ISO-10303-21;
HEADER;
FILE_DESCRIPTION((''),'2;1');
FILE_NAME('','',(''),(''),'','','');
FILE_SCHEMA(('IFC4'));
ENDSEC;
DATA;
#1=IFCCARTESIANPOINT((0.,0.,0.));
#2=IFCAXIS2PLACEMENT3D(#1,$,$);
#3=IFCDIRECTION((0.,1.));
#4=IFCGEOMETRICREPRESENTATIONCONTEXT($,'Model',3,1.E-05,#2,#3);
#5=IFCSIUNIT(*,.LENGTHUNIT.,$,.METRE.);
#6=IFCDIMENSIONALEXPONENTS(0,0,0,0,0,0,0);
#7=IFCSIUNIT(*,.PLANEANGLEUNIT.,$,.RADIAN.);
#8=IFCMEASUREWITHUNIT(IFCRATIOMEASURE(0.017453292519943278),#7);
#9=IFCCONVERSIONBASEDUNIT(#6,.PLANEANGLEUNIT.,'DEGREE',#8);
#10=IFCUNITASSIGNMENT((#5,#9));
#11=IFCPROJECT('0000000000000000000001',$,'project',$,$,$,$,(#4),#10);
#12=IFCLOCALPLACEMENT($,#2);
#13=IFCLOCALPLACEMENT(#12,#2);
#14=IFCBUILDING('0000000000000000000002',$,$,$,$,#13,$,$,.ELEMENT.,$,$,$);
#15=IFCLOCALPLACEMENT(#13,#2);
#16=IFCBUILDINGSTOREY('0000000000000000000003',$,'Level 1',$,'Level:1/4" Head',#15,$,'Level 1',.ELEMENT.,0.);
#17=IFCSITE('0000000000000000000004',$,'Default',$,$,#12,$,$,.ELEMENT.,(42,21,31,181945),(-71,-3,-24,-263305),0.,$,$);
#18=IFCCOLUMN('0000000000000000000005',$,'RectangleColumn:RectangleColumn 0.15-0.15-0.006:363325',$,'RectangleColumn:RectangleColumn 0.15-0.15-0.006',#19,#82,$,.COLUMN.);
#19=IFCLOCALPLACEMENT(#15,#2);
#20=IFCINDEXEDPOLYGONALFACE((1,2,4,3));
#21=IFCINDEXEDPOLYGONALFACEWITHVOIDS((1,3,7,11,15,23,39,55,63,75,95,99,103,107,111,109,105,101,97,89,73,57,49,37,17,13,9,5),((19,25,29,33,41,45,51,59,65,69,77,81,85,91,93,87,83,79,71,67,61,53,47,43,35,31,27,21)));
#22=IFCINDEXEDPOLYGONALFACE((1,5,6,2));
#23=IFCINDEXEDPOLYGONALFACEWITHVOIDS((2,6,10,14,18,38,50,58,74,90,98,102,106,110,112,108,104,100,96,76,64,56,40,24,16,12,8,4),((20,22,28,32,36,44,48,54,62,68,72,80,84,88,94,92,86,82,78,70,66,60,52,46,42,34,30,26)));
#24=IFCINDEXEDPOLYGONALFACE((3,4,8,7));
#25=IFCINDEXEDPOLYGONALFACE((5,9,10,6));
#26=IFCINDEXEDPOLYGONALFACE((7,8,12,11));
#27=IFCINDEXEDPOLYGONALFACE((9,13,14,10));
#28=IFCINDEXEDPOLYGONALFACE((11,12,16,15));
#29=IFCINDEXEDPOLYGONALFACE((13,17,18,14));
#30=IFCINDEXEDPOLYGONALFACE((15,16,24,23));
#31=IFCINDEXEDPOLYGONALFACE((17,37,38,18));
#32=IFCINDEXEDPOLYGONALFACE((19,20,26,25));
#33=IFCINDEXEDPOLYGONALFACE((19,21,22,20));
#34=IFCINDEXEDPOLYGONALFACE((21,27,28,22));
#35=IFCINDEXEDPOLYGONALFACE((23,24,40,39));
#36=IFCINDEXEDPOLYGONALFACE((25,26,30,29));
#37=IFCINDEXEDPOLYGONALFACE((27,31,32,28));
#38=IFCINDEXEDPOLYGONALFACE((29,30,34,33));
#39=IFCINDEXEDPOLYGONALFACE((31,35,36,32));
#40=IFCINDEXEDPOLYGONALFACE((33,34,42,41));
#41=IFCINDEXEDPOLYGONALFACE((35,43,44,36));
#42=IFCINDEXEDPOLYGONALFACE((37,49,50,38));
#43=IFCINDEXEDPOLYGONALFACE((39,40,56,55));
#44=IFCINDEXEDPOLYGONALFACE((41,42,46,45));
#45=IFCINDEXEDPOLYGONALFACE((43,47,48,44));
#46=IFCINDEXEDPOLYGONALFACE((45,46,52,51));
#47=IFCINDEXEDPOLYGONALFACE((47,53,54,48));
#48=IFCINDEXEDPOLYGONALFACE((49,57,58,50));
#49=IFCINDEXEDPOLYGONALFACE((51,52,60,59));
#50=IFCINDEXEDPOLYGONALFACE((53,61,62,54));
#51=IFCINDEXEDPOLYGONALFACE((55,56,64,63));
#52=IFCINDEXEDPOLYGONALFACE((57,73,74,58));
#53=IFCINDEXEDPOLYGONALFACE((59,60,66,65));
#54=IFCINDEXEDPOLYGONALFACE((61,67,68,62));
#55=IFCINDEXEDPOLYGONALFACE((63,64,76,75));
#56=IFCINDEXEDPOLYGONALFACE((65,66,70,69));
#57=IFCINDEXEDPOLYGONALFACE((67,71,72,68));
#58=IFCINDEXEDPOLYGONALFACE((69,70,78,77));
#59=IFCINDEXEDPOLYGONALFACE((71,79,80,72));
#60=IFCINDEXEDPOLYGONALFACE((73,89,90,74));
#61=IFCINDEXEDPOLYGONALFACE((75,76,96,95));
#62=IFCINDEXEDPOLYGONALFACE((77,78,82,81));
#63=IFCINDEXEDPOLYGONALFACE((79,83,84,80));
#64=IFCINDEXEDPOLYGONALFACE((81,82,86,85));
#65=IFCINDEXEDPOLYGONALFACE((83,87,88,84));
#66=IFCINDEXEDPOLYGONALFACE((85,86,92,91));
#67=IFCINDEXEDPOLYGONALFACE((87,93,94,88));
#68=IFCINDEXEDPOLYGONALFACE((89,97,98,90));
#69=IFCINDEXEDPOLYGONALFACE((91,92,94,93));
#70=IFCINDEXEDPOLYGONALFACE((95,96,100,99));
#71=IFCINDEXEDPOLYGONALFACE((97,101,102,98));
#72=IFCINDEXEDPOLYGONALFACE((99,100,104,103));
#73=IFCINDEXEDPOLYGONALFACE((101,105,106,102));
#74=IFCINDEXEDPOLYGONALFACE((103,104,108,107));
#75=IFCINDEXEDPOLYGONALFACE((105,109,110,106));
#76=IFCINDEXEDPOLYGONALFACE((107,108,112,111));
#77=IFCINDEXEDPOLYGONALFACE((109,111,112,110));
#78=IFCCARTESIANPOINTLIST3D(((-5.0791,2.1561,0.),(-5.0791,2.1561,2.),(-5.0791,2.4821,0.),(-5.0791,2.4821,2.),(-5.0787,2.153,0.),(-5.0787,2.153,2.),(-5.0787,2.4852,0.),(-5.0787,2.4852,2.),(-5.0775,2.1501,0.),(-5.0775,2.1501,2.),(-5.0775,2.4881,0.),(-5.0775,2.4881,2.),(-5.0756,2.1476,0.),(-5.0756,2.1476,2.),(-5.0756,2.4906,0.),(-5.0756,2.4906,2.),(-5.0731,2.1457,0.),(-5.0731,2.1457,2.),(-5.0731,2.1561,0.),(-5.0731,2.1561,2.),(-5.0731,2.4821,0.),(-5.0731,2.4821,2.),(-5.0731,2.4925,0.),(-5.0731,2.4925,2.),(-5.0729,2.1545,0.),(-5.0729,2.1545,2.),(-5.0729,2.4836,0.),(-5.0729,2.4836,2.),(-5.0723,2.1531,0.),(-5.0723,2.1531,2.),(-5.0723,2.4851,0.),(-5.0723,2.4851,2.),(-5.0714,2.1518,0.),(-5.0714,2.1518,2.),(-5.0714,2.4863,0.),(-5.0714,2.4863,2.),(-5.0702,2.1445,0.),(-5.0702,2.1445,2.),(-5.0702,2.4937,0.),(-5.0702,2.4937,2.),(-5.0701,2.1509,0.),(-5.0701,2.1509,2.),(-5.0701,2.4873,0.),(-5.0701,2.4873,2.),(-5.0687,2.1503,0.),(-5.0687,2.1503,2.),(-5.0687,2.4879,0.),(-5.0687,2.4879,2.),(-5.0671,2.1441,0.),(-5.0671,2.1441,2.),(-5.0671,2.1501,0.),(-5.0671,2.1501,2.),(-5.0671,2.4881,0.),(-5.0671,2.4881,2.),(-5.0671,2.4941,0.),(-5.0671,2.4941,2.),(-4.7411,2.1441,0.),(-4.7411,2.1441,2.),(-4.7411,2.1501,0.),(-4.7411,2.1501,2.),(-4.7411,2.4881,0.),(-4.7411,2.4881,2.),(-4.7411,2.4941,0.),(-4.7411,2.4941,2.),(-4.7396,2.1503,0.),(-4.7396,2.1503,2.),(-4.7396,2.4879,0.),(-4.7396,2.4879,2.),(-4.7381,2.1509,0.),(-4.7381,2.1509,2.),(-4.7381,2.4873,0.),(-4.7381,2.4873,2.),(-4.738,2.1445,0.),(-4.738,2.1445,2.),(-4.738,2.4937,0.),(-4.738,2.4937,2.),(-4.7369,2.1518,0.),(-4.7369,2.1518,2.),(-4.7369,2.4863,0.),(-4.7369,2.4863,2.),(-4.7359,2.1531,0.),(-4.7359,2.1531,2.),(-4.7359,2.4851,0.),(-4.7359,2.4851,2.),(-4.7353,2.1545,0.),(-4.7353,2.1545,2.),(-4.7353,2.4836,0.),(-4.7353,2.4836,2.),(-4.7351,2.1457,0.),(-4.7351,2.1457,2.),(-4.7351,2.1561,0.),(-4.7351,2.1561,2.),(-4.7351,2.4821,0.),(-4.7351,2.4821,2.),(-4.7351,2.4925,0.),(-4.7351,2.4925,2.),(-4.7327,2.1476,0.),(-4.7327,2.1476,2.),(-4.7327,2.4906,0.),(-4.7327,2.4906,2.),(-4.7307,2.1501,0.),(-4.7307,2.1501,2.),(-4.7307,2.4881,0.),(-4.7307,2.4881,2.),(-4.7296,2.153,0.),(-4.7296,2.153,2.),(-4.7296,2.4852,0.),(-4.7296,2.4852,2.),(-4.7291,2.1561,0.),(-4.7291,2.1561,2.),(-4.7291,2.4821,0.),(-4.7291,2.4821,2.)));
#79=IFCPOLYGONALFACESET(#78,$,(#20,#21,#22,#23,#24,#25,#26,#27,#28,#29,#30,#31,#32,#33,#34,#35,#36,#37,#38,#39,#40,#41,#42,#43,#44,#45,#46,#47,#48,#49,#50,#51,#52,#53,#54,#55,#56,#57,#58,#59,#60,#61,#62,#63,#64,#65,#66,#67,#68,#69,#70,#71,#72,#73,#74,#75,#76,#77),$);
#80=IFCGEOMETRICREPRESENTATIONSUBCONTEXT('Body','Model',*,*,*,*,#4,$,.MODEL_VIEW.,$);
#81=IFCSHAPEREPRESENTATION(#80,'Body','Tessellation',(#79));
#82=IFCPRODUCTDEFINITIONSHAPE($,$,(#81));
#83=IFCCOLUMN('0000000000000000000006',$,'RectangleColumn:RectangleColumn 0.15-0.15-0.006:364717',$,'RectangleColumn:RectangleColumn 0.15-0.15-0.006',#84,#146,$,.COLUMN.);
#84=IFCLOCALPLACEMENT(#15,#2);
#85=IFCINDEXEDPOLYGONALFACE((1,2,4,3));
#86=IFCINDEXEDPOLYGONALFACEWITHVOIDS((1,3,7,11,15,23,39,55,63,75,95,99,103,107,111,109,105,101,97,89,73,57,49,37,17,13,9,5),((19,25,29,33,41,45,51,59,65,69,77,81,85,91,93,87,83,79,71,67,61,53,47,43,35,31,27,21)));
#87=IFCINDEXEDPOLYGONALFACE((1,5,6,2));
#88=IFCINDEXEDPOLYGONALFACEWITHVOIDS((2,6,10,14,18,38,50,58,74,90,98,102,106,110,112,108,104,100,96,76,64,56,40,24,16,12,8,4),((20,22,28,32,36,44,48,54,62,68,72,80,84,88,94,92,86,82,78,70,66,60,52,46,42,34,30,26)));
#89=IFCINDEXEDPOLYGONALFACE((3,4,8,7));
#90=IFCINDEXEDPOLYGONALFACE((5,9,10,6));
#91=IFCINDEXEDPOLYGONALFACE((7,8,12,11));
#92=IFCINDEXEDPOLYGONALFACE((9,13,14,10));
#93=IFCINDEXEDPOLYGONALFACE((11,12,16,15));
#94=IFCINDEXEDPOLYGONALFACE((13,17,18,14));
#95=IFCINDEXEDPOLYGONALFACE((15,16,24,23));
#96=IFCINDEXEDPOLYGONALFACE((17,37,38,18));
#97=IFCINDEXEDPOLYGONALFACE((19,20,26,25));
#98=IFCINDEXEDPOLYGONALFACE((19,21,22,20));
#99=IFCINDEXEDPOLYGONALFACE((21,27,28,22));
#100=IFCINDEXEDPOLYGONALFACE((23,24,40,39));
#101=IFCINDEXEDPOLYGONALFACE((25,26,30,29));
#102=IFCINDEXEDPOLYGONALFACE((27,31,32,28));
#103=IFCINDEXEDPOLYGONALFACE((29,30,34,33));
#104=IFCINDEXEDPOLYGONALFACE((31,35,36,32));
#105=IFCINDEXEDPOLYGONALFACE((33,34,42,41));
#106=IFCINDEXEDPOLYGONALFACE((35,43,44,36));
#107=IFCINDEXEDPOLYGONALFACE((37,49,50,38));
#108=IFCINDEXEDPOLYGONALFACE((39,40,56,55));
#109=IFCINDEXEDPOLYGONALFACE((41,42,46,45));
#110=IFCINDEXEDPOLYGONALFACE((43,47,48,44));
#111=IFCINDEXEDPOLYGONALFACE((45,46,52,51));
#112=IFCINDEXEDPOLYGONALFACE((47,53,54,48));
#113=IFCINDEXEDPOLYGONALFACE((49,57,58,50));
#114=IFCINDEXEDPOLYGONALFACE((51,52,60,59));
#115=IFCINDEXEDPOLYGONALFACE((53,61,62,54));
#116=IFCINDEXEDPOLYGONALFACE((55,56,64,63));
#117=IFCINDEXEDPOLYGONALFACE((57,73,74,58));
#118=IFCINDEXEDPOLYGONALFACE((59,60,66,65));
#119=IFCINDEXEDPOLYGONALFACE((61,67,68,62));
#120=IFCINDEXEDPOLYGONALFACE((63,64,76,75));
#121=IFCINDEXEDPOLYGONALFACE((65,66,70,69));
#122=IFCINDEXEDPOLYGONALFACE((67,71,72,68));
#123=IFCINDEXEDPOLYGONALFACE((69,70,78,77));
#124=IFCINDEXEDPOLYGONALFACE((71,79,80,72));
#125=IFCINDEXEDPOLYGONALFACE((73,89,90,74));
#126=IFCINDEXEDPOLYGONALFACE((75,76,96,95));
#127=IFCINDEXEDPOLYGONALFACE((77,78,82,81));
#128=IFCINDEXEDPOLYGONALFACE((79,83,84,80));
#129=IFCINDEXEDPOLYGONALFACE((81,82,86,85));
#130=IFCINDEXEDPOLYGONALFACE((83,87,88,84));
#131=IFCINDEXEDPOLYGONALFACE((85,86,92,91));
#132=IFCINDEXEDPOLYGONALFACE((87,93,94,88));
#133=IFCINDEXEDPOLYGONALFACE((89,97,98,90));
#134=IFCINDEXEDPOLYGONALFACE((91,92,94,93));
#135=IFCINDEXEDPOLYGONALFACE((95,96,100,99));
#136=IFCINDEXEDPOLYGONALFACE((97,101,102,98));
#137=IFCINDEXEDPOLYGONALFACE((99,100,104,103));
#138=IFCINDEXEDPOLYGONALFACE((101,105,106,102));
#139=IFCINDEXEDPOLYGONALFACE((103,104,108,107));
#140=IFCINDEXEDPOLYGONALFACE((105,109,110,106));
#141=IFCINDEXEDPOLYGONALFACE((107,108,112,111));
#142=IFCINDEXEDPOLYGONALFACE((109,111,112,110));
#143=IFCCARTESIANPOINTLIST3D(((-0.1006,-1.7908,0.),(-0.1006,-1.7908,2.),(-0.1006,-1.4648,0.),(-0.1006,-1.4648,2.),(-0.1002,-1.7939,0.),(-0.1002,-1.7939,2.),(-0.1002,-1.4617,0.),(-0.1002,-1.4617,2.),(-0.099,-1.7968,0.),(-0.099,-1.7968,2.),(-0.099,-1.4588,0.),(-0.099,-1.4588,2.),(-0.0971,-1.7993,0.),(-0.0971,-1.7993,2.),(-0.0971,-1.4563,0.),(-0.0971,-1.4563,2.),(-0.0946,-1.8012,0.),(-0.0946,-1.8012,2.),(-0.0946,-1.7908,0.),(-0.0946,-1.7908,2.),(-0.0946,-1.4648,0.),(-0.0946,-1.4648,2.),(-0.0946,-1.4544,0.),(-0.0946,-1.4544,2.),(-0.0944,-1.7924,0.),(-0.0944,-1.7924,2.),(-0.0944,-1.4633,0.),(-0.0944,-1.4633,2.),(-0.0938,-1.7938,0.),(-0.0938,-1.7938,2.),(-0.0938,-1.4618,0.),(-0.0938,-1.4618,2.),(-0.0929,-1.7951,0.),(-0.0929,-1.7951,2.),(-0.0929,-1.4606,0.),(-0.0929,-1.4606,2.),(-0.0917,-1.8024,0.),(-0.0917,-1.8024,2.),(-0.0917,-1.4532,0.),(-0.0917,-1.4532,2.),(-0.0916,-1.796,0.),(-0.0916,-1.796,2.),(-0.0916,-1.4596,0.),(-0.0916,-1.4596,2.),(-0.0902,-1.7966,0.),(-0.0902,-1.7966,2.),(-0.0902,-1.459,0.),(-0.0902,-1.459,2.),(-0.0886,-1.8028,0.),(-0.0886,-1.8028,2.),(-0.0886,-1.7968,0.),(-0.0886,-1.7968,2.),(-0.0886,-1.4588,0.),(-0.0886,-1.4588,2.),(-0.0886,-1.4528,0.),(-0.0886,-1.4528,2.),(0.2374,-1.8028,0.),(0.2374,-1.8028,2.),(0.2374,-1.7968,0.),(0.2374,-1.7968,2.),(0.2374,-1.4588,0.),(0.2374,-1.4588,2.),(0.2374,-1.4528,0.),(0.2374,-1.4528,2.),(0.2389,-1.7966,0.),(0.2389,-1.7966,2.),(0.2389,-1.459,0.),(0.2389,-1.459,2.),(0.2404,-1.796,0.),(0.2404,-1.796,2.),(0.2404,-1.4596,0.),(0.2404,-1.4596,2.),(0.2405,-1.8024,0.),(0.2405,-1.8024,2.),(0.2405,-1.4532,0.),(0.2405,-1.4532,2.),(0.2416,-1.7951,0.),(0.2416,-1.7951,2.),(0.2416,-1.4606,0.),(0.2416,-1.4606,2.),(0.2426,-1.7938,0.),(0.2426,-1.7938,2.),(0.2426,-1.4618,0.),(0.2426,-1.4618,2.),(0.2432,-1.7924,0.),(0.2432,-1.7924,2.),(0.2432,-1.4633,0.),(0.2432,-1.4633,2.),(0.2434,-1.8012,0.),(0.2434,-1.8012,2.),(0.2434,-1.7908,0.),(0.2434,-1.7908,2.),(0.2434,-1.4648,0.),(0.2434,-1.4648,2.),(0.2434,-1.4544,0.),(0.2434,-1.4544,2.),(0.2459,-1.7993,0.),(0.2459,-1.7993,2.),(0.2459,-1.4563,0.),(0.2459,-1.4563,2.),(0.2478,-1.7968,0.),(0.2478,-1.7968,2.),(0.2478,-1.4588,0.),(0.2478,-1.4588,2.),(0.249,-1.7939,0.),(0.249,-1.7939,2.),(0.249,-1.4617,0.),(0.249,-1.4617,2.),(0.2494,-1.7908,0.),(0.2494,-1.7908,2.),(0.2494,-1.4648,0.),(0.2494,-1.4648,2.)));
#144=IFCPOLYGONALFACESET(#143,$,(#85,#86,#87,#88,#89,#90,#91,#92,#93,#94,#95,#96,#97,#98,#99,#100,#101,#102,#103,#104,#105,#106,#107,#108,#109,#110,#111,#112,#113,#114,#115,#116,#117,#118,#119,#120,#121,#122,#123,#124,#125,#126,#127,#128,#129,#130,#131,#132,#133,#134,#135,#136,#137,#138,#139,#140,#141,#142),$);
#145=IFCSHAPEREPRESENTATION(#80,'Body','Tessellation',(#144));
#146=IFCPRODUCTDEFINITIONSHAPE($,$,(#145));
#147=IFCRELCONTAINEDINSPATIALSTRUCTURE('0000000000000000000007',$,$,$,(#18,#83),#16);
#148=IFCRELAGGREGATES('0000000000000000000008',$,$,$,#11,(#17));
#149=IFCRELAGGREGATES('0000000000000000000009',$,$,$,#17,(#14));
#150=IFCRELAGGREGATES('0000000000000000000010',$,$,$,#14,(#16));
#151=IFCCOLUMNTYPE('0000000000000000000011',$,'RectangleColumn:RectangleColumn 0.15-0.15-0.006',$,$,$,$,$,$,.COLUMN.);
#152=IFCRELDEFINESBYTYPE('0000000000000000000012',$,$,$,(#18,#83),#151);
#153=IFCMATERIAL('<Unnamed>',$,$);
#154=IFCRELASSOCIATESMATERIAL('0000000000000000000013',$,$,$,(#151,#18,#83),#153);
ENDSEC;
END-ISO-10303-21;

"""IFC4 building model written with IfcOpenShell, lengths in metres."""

from ifc_helpers import new_model, entity, si_unit, converted_unit, direction, frame, origin, place, context, subcontext, project, spatial, line, arc, indexed_curve, outline, extrude, source, transform, mapped, material, type_object, type_shapes, element, save


model = new_model("IFC4")

# Units and contexts
model_context = context("Model", 3, precision=1e-05, world=origin(), true_north=direction((0.0, 1.0)))
body_context = subcontext(model_context, "Body", "Model", "MODEL_VIEW")
ifc_project = project(units=[si_unit("LENGTHUNIT", "METRE"), converted_unit("PLANEANGLEUNIT", "DEGREE", entity("IfcRatioMeasure", 0.017453292519943278), si_unit("PLANEANGLEUNIT", "RADIAN"), dimensions=[0, 0, 0, 0, 0, 0, 0])], contexts=[model_context])

# Site, building, storey
site_placement = place(None, origin())
site = spatial("IfcSite", under=ifc_project, at=site_placement, Name="Default", CompositionType="ELEMENT", RefLatitude=(42, 21, 31, 181945), RefLongitude=(-71, -3, -24, -263305), RefElevation=0.0)
building_placement = place(site_placement, origin())
building = spatial("IfcBuilding", under=site, at=building_placement, CompositionType="ELEMENT")
storey_placement = place(building_placement, origin())
storey = spatial("IfcBuildingStorey", under=building, at=storey_placement, Name="Level 1", ObjectType="Level:1/4\" Head", LongName="Level 1", CompositionType="ELEMENT", Elevation=0.0)

# Columns
ifc_material_1 = material(Name="<Unnamed>")
column_type = type_object("IfcColumnType", Name="RectangleColumn:RectangleColumn 0.15-0.15-0.006", PredefinedType="COLUMN", material=ifc_material_1)
shared_shape = source(origin(), body_context, "Body", "SweptSolid", [
    extrude(outline(indexed_curve([(-0.163, -0.175), (0.163, -0.175), (0.1715, -0.1715), (0.175, -0.163), (0.175, 0.163), (0.1715, 0.1715), (0.163, 0.175), (-0.163, 0.175), (-0.1715, 0.1715), (-0.175, 0.163), (-0.175, -0.163), (-0.1715, -0.1715)], segments=[line(1, 2), arc(2, 3, 4), line(4, 5), arc(5, 6, 7), line(7, 8), arc(8, 9, 10), line(10, 11), arc(11, 12, 1)], self_intersect=False), holes=[indexed_curve([(-0.163, -0.169), (-0.1672, -0.1672), (-0.169, -0.163), (-0.169, 0.163), (-0.1672, 0.1672), (-0.163, 0.169), (0.163, 0.169), (0.1672, 0.1672), (0.169, 0.163), (0.169, -0.163), (0.1672, -0.1672), (0.163, -0.169)], segments=[arc(1, 2, 3), line(3, 4), arc(4, 5, 6), line(6, 7), arc(7, 8, 9), line(9, 10), arc(10, 11, 12), line(12, 1)], self_intersect=False)]), frame((0.0, 0.0, 0.0), z_axis=(0.0, 0.0, 1.0), x_axis=(-1.0, 0.0, 0.0)), (0.0, 0.0, 1.0), 2.0),
])
type_shapes(column_type, [shared_shape])
for number, where, name in (
    (1, (-4.9041, 2.3191, 0.0), "RectangleColumn:RectangleColumn 0.15-0.15-0.006:363325"),
    (2, (0.0744, -1.6278, 0.0), "RectangleColumn:RectangleColumn 0.15-0.15-0.006:364717"),
):
    element("IfcColumn", number, at=place(storey_placement, frame(where)), inside=storey, type_object=column_type, material=ifc_material_1, Name=name, ObjectType="RectangleColumn:RectangleColumn 0.15-0.15-0.006", PredefinedType="COLUMN", context=body_context, shape_type="MappedRepresentation", body=[
        mapped(shared_shape, transform((0.0, 0.0, 0.0), scale=1.0)),
    ])

save(model, "model.ifc")
